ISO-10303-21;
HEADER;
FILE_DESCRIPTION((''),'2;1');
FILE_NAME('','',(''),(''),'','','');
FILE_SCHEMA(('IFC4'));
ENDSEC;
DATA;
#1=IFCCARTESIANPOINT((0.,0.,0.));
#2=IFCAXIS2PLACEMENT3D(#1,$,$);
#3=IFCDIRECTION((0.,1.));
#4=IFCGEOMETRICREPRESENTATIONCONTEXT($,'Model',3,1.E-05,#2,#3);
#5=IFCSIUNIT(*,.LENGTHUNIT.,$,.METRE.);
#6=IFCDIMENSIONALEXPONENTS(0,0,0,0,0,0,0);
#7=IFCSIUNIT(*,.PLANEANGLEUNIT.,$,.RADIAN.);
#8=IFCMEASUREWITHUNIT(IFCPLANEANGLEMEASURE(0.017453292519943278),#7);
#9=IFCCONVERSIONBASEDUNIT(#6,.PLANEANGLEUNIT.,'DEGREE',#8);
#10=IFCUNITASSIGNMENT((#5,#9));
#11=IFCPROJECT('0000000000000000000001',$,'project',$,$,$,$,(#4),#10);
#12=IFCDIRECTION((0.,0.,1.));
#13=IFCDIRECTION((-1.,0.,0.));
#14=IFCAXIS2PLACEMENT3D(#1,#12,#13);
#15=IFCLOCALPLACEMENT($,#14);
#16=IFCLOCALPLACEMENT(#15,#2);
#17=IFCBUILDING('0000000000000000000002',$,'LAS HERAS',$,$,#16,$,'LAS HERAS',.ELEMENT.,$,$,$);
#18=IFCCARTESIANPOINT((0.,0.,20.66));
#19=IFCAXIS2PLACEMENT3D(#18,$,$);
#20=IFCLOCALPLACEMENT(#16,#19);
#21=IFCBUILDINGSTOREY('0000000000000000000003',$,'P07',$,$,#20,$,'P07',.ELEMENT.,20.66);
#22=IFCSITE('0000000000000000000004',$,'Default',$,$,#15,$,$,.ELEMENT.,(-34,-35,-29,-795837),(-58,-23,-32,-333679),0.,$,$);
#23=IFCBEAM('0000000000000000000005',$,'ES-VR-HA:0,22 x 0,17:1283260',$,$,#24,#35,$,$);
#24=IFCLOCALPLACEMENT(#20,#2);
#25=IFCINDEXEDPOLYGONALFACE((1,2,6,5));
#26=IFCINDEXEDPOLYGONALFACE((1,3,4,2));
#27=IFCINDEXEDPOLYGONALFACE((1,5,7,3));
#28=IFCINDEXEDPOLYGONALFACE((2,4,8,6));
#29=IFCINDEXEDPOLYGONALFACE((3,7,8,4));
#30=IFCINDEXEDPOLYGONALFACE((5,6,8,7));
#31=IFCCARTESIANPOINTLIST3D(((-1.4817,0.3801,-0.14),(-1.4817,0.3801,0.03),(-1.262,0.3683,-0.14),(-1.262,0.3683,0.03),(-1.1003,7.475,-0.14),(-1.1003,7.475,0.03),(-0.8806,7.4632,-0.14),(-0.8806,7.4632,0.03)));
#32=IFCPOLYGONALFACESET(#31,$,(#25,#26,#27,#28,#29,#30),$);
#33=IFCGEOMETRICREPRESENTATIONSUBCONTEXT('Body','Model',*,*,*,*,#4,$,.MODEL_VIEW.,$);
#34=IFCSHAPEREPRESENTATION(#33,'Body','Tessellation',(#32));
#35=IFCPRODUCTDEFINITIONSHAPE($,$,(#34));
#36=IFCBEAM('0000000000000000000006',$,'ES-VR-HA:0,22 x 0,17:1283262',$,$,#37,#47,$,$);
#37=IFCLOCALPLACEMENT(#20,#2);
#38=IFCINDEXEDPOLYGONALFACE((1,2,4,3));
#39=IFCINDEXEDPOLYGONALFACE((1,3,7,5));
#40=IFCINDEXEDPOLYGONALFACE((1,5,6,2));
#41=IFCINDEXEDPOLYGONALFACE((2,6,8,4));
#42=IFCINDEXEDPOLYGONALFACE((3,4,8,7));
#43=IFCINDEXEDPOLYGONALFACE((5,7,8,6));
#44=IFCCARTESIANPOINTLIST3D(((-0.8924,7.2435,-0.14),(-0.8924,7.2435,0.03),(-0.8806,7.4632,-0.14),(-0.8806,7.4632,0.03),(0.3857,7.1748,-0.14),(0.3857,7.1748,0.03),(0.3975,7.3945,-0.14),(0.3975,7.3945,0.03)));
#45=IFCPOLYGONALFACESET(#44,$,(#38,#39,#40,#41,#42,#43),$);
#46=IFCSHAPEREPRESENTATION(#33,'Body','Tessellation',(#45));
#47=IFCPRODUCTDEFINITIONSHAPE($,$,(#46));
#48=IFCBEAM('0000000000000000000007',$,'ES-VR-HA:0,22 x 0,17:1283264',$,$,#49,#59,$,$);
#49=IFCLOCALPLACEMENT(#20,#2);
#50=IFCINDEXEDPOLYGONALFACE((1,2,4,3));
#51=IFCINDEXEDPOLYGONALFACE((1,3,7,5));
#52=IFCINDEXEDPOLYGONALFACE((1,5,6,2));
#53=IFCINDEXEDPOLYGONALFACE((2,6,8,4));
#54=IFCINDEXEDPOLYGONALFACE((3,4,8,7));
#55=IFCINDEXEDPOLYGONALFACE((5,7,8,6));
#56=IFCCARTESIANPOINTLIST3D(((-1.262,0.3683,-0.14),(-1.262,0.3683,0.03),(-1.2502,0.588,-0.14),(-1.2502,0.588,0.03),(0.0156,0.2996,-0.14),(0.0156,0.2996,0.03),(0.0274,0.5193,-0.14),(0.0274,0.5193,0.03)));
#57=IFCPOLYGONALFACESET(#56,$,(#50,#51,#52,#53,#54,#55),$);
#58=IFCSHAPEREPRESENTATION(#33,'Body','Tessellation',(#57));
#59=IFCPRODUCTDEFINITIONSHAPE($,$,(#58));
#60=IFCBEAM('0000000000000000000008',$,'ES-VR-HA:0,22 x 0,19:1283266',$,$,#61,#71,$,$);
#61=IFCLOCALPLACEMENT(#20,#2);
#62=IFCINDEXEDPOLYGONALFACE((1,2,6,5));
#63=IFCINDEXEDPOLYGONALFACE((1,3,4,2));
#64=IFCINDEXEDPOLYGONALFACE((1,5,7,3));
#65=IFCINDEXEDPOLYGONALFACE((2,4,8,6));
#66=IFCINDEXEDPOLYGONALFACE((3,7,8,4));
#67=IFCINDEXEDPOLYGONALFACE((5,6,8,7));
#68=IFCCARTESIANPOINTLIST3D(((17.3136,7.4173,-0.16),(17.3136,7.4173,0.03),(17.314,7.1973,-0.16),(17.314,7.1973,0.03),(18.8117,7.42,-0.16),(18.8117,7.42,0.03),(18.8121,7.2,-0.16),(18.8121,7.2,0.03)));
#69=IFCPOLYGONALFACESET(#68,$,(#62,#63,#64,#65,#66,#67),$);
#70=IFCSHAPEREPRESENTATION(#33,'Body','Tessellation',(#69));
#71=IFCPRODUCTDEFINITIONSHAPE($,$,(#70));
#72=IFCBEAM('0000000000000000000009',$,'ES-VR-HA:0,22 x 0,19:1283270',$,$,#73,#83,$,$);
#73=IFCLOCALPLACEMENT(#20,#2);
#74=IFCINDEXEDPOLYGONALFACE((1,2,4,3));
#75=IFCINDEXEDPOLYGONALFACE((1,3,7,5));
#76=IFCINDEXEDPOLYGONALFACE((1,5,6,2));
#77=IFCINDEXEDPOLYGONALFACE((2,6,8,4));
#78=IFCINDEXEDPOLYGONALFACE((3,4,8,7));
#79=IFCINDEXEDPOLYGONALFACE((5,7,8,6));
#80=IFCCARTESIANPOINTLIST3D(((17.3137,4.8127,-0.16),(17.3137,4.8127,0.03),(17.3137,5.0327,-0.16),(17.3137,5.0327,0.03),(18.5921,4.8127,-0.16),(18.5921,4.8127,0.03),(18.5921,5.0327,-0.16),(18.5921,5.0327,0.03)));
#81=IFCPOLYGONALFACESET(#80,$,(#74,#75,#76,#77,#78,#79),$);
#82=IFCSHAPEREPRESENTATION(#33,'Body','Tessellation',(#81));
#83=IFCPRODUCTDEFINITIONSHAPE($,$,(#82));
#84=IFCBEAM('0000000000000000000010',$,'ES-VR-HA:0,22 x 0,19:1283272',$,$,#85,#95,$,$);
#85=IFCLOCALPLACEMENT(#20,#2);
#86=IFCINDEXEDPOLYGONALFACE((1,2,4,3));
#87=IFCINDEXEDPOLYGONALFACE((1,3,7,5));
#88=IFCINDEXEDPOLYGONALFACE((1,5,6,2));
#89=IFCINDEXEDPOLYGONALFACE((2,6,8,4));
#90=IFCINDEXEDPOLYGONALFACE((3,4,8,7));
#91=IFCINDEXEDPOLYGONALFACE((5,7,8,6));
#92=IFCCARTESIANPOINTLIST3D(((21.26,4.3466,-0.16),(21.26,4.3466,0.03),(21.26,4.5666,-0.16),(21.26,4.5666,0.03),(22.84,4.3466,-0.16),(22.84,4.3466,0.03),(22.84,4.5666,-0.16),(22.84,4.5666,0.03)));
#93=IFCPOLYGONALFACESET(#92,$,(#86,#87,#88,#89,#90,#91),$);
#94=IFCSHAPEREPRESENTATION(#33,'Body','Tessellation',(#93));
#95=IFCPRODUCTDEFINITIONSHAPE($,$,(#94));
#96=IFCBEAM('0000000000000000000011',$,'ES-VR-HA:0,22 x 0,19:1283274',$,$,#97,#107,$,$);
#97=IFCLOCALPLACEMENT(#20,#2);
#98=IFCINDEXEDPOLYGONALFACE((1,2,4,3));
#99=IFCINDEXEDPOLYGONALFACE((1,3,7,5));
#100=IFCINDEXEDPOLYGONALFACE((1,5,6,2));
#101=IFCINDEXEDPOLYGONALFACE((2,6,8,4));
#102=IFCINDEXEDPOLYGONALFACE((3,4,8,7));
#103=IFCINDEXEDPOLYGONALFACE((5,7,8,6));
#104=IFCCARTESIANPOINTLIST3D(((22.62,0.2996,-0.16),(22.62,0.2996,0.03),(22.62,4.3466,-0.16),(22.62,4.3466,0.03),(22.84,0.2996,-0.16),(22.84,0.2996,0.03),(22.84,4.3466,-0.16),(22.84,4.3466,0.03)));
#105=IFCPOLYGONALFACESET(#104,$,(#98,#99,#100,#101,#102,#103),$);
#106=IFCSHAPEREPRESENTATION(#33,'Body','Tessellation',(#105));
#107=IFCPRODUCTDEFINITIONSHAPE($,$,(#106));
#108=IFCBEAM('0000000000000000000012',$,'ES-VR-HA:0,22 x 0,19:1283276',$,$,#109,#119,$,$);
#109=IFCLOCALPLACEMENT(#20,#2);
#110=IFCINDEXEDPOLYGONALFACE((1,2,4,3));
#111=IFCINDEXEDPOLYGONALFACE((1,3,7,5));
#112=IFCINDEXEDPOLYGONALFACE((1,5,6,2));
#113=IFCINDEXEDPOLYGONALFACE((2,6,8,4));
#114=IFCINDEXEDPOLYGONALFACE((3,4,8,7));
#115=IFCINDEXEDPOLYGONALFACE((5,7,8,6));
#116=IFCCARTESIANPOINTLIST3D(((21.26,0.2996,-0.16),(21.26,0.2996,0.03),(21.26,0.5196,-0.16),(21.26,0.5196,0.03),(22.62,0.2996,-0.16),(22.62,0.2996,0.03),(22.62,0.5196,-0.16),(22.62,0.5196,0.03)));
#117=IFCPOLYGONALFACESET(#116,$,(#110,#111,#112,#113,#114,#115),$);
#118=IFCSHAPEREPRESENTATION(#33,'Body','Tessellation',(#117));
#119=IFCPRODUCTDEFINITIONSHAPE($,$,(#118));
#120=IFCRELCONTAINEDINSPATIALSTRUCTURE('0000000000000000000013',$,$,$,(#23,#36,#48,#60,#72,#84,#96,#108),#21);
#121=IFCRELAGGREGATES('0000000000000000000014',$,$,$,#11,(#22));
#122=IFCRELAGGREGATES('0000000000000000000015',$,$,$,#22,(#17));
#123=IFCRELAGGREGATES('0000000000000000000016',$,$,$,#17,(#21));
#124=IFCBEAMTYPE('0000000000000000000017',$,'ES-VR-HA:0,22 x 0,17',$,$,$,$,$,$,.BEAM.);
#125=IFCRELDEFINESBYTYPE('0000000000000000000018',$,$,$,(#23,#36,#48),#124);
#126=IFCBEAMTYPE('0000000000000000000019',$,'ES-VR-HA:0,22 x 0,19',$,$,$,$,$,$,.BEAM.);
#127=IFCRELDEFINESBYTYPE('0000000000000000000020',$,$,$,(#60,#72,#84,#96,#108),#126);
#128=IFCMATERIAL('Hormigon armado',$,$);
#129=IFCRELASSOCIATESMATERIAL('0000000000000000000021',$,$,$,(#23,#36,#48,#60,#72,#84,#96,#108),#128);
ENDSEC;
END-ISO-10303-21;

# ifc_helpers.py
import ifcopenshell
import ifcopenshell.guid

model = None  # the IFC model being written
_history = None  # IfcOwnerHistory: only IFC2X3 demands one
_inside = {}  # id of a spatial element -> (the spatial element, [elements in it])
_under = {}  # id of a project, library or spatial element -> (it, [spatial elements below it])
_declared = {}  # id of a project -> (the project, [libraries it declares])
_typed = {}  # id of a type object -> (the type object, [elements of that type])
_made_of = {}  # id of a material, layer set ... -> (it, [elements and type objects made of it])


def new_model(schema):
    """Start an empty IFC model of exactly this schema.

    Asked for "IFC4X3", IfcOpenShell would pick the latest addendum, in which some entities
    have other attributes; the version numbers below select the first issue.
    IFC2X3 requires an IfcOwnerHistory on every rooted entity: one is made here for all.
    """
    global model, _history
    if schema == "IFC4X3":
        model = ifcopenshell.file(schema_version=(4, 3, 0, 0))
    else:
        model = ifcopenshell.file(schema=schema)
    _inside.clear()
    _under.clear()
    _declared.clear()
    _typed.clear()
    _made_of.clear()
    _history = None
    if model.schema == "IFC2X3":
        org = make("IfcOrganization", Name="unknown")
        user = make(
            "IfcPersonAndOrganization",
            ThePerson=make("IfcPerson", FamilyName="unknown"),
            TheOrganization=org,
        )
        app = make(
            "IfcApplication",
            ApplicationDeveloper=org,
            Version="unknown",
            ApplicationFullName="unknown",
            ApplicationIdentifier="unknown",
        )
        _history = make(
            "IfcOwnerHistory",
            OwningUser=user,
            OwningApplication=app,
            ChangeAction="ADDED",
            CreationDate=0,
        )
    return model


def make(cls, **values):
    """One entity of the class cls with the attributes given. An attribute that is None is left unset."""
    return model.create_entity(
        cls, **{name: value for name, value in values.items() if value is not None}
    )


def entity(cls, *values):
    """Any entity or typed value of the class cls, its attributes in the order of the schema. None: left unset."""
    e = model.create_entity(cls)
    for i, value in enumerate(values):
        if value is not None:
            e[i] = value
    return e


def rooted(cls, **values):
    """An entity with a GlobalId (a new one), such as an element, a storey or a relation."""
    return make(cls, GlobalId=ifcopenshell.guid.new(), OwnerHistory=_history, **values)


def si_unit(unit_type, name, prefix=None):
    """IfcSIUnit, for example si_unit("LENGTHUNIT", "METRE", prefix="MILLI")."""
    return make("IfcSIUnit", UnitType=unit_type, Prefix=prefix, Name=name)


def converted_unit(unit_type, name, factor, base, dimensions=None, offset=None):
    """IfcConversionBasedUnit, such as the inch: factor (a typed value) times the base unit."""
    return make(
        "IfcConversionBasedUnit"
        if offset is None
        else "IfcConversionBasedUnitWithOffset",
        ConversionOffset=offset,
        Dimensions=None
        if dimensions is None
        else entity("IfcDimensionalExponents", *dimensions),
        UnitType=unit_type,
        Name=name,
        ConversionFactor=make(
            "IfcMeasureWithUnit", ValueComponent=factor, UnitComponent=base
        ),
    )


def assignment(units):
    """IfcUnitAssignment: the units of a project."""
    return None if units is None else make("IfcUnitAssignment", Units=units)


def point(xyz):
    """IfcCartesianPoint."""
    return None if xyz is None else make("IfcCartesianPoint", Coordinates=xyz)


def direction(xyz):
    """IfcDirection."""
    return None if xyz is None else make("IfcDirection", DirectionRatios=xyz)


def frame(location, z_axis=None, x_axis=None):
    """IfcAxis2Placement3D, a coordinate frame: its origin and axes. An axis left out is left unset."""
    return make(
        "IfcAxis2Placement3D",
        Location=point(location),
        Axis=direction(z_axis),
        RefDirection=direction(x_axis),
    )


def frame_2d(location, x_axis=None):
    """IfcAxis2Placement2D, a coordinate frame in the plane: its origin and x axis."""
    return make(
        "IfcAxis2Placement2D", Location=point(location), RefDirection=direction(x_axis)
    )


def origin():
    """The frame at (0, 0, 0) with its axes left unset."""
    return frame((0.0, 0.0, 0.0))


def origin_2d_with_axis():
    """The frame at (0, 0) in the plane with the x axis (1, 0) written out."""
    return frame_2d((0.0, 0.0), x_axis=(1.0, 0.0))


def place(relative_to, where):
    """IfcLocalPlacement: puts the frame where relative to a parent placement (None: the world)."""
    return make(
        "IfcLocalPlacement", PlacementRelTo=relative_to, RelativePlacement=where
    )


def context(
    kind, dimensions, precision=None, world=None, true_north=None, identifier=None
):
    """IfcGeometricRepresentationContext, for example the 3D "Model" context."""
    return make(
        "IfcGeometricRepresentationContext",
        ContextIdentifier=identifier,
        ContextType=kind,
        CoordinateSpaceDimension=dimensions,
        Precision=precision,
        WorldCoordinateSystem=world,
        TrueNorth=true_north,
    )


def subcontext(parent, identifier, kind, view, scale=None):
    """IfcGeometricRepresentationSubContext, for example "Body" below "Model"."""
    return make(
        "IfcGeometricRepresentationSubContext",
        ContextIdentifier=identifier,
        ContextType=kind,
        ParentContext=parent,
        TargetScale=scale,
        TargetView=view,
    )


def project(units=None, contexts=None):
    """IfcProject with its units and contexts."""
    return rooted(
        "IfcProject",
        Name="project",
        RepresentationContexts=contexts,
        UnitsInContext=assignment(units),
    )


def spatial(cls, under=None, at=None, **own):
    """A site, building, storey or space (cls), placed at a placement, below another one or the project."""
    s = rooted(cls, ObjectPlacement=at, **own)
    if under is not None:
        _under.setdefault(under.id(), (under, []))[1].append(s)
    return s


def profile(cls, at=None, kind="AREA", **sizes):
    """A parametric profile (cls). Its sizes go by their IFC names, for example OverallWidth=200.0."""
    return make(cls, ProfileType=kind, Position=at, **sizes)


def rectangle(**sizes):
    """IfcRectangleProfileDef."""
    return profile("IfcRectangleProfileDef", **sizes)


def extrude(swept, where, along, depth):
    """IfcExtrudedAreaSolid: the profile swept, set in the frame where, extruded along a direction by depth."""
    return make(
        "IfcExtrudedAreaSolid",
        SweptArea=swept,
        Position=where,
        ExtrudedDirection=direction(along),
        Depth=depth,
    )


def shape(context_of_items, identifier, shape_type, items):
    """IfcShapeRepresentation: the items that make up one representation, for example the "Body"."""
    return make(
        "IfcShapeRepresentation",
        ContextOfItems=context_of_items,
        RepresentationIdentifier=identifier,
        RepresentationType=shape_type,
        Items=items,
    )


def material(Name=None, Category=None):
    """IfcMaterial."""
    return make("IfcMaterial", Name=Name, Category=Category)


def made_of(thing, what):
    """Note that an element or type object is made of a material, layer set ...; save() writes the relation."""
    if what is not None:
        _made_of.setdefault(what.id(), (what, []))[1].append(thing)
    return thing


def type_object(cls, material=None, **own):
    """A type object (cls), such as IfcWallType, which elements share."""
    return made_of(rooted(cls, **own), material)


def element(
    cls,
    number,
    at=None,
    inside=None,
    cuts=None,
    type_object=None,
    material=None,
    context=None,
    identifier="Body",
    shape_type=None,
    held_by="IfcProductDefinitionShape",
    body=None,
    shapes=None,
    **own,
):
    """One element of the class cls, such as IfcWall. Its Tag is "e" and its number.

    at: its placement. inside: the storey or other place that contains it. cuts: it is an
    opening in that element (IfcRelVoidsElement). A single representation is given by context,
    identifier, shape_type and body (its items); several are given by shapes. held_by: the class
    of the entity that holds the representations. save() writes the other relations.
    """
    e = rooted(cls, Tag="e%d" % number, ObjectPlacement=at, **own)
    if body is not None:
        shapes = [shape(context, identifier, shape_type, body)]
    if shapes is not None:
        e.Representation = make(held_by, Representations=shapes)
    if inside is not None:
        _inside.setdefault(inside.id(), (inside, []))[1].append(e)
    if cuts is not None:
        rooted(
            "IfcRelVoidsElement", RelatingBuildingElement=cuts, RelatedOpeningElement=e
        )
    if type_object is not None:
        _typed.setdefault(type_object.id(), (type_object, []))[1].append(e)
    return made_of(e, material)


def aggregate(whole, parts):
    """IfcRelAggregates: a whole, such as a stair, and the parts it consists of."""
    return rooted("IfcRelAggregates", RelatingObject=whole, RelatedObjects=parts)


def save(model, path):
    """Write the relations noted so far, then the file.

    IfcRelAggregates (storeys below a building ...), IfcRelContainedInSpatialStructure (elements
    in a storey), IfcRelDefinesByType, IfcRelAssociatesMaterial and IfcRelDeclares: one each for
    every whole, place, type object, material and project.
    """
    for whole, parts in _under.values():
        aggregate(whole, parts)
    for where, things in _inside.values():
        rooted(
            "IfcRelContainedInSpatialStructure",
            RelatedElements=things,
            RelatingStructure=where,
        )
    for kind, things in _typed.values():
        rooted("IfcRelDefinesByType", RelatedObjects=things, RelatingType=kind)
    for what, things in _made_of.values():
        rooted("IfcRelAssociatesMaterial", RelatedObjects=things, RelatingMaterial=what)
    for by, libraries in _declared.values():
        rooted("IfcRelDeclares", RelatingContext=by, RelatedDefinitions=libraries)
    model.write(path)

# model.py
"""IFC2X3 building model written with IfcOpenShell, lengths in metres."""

from ifc_helpers import new_model, entity, si_unit, converted_unit, direction, frame, frame_2d, origin, origin_2d_with_axis, place, context, subcontext, project, spatial, rectangle, extrude, material, type_object, element, save


model = new_model("IFC2X3")

# Units and contexts
model_context = context("Model", 3, precision=1e-05, world=origin(), true_north=direction((0.0, 1.0)))
body_context = subcontext(model_context, "Body", "Model", "MODEL_VIEW")
ifc_project = project(units=[si_unit("LENGTHUNIT", "METRE"), converted_unit("PLANEANGLEUNIT", "DEGREE", entity("IfcPlaneAngleMeasure", 0.017453292519943278), si_unit("PLANEANGLEUNIT", "RADIAN"), dimensions=[0, 0, 0, 0, 0, 0, 0])], contexts=[model_context])

# Site, building, storey
site_placement = place(None, frame((0.0, 0.0, 0.0), z_axis=(0.0, 0.0, 1.0), x_axis=(-1.0, 0.0, 0.0)))
site = spatial("IfcSite", under=ifc_project, at=site_placement, Name="Default", CompositionType="ELEMENT", RefLatitude=(-34, -35, -29, -795837), RefLongitude=(-58, -23, -32, -333679), RefElevation=0.0)
building_placement = place(site_placement, origin())
building = spatial("IfcBuilding", under=site, at=building_placement, Name="LAS HERAS", LongName="LAS HERAS", CompositionType="ELEMENT")
storey_placement = place(building_placement, frame((0.0, 0.0, 20.66)))
storey = spatial("IfcBuildingStorey", under=building, at=storey_placement, Name="P07", LongName="P07", CompositionType="ELEMENT", Elevation=20.66)

# Beams
ifc_material = material(Name="Hormigon armado")
beam_type_1 = type_object("IfcBeamType", Name="ES-VR-HA:0,22 x 0,17", PredefinedType="BEAM")
beam_1_placement = place(storey_placement, frame((-0.9963, 7.3593, 0.03), z_axis=(0.0, 0.0, 1.0), x_axis=(-0.05369, -0.998558, 0.0)))
element("IfcBeam", 1, at=beam_1_placement, inside=storey, type_object=beam_type_1, material=ifc_material, Name="ES-VR-HA:0,22 x 0,17:1283260", context=body_context, shape_type="SweptSolid", body=[
    extrude(rectangle(XDim=0.17, YDim=0.22, at=frame_2d((0.0, 0.0), x_axis=(1.0, 0.0))), frame((-0.11, 0.0, -0.085), z_axis=(1.0, 0.0, 0.0), x_axis=(0.0, 0.0, -1.0)), (0.0, 0.0, 1.0), 7.1052),
])
beam_2_placement = place(storey_placement, frame((0.3916, 7.2846, 0.03), z_axis=(0.0, 0.0, 1.0), x_axis=(-0.998558, 0.05368, 0.0)))
element("IfcBeam", 2, at=beam_2_placement, inside=storey, type_object=beam_type_1, material=ifc_material, Name="ES-VR-HA:0,22 x 0,17:1283262", context=body_context, shape_type="SweptSolid", body=[
    extrude(rectangle(XDim=0.17, YDim=0.22, at=frame_2d((0.0, 0.0), x_axis=(1.0, 0.0))), frame((0.0, 0.0, -0.085), z_axis=(1.0, 0.0, 0.0), x_axis=(0.0, 0.0, -1.0)), (0.0, 0.0, 1.0), 1.28),
])
beam_3_placement = place(storey_placement, frame((0.0215, 0.4094, 0.03), z_axis=(0.0, 0.0, 1.0), x_axis=(-0.998558, 0.05369, 0.0)))
element("IfcBeam", 3, at=beam_3_placement, inside=storey, type_object=beam_type_1, material=ifc_material, Name="ES-VR-HA:0,22 x 0,17:1283264", context=body_context, shape_type="SweptSolid", body=[
    extrude(rectangle(XDim=0.17, YDim=0.22, at=frame_2d((0.0, 0.0), x_axis=(1.0, 0.0))), frame((0.0, 0.0, -0.085), z_axis=(1.0, 0.0, 0.0), x_axis=(0.0, 0.0, -1.0)), (0.0, 0.0, 1.0), 1.2795),
])
beam_type_2 = type_object("IfcBeamType", Name="ES-VR-HA:0,22 x 0,19", PredefinedType="BEAM")
beam_4_placement = place(storey_placement, frame((17.3138, 7.3073, 0.03), z_axis=(0.0, 0.0, 1.0), x_axis=(0.999998, 0.001781, 0.0)))
element("IfcBeam", 4, at=beam_4_placement, inside=storey, type_object=beam_type_2, material=ifc_material, Name="ES-VR-HA:0,22 x 0,19:1283266", context=body_context, shape_type="SweptSolid", body=[
    extrude(rectangle(XDim=0.19, YDim=0.22, at=frame_2d((0.0, 0.0), x_axis=(1.0, 0.0))), frame((0.0, 0.0, -0.095), z_axis=(1.0, 0.0, 0.0), x_axis=(0.0, 0.0, -1.0)), (0.0, 0.0, 1.0), 1.4981),
])
beam_5_placement = place(storey_placement, frame((17.3137, 4.9227, 0.03)))
element("IfcBeam", 5, at=beam_5_placement, inside=storey, type_object=beam_type_2, material=ifc_material, Name="ES-VR-HA:0,22 x 0,19:1283270", context=body_context, shape_type="SweptSolid", body=[
    extrude(rectangle(XDim=0.19, YDim=0.22, at=frame_2d((0.0, 0.0), x_axis=(1.0, 0.0))), frame((0.0, 0.0, -0.095), z_axis=(1.0, 0.0, 0.0), x_axis=(0.0, 0.0, -1.0)), (0.0, 0.0, 1.0), 1.2784),
])
beam_6_placement = place(storey_placement, frame((21.26, 4.4566, 0.03)))
element("IfcBeam", 6, at=beam_6_placement, inside=storey, type_object=beam_type_2, material=ifc_material, Name="ES-VR-HA:0,22 x 0,19:1283272", context=body_context, shape_type="SweptSolid", body=[
    extrude(rectangle(XDim=0.19, YDim=0.22, at=origin_2d_with_axis()), frame((0.0, 0.0, -0.095), z_axis=(1.0, 0.0, 0.0), x_axis=(0.0, 0.0, -1.0)), (0.0, 0.0, 1.0), 1.58),
])
beam_7_placement = place(storey_placement, frame((22.73, 4.4566, 0.03), z_axis=(0.0, 0.0, 1.0), x_axis=(0.0, -1.0, 0.0)))
element("IfcBeam", 7, at=beam_7_placement, inside=storey, type_object=beam_type_2, material=ifc_material, Name="ES-VR-HA:0,22 x 0,19:1283274", context=body_context, shape_type="SweptSolid", body=[
    extrude(rectangle(XDim=0.19, YDim=0.22, at=frame_2d((0.0, 0.0), x_axis=(1.0, 0.0))), frame((0.11, 0.0, -0.095), z_axis=(1.0, 0.0, 0.0), x_axis=(0.0, 0.0, -1.0)), (0.0, 0.0, 1.0), 4.0471),
])
beam_8_placement = place(storey_placement, frame((21.26, 0.4096, 0.03)))
element("IfcBeam", 8, at=beam_8_placement, inside=storey, type_object=beam_type_2, material=ifc_material, Name="ES-VR-HA:0,22 x 0,19:1283276", context=body_context, shape_type="SweptSolid", body=[
    extrude(rectangle(XDim=0.19, YDim=0.22, at=frame_2d((0.0, 0.0), x_axis=(1.0, 0.0))), frame((0.0, 0.0, -0.095), z_axis=(1.0, 0.0, 0.0), x_axis=(0.0, 0.0, -1.0)), (0.0, 0.0, 1.0), 1.36),
])

save(model, "model.ifc")
